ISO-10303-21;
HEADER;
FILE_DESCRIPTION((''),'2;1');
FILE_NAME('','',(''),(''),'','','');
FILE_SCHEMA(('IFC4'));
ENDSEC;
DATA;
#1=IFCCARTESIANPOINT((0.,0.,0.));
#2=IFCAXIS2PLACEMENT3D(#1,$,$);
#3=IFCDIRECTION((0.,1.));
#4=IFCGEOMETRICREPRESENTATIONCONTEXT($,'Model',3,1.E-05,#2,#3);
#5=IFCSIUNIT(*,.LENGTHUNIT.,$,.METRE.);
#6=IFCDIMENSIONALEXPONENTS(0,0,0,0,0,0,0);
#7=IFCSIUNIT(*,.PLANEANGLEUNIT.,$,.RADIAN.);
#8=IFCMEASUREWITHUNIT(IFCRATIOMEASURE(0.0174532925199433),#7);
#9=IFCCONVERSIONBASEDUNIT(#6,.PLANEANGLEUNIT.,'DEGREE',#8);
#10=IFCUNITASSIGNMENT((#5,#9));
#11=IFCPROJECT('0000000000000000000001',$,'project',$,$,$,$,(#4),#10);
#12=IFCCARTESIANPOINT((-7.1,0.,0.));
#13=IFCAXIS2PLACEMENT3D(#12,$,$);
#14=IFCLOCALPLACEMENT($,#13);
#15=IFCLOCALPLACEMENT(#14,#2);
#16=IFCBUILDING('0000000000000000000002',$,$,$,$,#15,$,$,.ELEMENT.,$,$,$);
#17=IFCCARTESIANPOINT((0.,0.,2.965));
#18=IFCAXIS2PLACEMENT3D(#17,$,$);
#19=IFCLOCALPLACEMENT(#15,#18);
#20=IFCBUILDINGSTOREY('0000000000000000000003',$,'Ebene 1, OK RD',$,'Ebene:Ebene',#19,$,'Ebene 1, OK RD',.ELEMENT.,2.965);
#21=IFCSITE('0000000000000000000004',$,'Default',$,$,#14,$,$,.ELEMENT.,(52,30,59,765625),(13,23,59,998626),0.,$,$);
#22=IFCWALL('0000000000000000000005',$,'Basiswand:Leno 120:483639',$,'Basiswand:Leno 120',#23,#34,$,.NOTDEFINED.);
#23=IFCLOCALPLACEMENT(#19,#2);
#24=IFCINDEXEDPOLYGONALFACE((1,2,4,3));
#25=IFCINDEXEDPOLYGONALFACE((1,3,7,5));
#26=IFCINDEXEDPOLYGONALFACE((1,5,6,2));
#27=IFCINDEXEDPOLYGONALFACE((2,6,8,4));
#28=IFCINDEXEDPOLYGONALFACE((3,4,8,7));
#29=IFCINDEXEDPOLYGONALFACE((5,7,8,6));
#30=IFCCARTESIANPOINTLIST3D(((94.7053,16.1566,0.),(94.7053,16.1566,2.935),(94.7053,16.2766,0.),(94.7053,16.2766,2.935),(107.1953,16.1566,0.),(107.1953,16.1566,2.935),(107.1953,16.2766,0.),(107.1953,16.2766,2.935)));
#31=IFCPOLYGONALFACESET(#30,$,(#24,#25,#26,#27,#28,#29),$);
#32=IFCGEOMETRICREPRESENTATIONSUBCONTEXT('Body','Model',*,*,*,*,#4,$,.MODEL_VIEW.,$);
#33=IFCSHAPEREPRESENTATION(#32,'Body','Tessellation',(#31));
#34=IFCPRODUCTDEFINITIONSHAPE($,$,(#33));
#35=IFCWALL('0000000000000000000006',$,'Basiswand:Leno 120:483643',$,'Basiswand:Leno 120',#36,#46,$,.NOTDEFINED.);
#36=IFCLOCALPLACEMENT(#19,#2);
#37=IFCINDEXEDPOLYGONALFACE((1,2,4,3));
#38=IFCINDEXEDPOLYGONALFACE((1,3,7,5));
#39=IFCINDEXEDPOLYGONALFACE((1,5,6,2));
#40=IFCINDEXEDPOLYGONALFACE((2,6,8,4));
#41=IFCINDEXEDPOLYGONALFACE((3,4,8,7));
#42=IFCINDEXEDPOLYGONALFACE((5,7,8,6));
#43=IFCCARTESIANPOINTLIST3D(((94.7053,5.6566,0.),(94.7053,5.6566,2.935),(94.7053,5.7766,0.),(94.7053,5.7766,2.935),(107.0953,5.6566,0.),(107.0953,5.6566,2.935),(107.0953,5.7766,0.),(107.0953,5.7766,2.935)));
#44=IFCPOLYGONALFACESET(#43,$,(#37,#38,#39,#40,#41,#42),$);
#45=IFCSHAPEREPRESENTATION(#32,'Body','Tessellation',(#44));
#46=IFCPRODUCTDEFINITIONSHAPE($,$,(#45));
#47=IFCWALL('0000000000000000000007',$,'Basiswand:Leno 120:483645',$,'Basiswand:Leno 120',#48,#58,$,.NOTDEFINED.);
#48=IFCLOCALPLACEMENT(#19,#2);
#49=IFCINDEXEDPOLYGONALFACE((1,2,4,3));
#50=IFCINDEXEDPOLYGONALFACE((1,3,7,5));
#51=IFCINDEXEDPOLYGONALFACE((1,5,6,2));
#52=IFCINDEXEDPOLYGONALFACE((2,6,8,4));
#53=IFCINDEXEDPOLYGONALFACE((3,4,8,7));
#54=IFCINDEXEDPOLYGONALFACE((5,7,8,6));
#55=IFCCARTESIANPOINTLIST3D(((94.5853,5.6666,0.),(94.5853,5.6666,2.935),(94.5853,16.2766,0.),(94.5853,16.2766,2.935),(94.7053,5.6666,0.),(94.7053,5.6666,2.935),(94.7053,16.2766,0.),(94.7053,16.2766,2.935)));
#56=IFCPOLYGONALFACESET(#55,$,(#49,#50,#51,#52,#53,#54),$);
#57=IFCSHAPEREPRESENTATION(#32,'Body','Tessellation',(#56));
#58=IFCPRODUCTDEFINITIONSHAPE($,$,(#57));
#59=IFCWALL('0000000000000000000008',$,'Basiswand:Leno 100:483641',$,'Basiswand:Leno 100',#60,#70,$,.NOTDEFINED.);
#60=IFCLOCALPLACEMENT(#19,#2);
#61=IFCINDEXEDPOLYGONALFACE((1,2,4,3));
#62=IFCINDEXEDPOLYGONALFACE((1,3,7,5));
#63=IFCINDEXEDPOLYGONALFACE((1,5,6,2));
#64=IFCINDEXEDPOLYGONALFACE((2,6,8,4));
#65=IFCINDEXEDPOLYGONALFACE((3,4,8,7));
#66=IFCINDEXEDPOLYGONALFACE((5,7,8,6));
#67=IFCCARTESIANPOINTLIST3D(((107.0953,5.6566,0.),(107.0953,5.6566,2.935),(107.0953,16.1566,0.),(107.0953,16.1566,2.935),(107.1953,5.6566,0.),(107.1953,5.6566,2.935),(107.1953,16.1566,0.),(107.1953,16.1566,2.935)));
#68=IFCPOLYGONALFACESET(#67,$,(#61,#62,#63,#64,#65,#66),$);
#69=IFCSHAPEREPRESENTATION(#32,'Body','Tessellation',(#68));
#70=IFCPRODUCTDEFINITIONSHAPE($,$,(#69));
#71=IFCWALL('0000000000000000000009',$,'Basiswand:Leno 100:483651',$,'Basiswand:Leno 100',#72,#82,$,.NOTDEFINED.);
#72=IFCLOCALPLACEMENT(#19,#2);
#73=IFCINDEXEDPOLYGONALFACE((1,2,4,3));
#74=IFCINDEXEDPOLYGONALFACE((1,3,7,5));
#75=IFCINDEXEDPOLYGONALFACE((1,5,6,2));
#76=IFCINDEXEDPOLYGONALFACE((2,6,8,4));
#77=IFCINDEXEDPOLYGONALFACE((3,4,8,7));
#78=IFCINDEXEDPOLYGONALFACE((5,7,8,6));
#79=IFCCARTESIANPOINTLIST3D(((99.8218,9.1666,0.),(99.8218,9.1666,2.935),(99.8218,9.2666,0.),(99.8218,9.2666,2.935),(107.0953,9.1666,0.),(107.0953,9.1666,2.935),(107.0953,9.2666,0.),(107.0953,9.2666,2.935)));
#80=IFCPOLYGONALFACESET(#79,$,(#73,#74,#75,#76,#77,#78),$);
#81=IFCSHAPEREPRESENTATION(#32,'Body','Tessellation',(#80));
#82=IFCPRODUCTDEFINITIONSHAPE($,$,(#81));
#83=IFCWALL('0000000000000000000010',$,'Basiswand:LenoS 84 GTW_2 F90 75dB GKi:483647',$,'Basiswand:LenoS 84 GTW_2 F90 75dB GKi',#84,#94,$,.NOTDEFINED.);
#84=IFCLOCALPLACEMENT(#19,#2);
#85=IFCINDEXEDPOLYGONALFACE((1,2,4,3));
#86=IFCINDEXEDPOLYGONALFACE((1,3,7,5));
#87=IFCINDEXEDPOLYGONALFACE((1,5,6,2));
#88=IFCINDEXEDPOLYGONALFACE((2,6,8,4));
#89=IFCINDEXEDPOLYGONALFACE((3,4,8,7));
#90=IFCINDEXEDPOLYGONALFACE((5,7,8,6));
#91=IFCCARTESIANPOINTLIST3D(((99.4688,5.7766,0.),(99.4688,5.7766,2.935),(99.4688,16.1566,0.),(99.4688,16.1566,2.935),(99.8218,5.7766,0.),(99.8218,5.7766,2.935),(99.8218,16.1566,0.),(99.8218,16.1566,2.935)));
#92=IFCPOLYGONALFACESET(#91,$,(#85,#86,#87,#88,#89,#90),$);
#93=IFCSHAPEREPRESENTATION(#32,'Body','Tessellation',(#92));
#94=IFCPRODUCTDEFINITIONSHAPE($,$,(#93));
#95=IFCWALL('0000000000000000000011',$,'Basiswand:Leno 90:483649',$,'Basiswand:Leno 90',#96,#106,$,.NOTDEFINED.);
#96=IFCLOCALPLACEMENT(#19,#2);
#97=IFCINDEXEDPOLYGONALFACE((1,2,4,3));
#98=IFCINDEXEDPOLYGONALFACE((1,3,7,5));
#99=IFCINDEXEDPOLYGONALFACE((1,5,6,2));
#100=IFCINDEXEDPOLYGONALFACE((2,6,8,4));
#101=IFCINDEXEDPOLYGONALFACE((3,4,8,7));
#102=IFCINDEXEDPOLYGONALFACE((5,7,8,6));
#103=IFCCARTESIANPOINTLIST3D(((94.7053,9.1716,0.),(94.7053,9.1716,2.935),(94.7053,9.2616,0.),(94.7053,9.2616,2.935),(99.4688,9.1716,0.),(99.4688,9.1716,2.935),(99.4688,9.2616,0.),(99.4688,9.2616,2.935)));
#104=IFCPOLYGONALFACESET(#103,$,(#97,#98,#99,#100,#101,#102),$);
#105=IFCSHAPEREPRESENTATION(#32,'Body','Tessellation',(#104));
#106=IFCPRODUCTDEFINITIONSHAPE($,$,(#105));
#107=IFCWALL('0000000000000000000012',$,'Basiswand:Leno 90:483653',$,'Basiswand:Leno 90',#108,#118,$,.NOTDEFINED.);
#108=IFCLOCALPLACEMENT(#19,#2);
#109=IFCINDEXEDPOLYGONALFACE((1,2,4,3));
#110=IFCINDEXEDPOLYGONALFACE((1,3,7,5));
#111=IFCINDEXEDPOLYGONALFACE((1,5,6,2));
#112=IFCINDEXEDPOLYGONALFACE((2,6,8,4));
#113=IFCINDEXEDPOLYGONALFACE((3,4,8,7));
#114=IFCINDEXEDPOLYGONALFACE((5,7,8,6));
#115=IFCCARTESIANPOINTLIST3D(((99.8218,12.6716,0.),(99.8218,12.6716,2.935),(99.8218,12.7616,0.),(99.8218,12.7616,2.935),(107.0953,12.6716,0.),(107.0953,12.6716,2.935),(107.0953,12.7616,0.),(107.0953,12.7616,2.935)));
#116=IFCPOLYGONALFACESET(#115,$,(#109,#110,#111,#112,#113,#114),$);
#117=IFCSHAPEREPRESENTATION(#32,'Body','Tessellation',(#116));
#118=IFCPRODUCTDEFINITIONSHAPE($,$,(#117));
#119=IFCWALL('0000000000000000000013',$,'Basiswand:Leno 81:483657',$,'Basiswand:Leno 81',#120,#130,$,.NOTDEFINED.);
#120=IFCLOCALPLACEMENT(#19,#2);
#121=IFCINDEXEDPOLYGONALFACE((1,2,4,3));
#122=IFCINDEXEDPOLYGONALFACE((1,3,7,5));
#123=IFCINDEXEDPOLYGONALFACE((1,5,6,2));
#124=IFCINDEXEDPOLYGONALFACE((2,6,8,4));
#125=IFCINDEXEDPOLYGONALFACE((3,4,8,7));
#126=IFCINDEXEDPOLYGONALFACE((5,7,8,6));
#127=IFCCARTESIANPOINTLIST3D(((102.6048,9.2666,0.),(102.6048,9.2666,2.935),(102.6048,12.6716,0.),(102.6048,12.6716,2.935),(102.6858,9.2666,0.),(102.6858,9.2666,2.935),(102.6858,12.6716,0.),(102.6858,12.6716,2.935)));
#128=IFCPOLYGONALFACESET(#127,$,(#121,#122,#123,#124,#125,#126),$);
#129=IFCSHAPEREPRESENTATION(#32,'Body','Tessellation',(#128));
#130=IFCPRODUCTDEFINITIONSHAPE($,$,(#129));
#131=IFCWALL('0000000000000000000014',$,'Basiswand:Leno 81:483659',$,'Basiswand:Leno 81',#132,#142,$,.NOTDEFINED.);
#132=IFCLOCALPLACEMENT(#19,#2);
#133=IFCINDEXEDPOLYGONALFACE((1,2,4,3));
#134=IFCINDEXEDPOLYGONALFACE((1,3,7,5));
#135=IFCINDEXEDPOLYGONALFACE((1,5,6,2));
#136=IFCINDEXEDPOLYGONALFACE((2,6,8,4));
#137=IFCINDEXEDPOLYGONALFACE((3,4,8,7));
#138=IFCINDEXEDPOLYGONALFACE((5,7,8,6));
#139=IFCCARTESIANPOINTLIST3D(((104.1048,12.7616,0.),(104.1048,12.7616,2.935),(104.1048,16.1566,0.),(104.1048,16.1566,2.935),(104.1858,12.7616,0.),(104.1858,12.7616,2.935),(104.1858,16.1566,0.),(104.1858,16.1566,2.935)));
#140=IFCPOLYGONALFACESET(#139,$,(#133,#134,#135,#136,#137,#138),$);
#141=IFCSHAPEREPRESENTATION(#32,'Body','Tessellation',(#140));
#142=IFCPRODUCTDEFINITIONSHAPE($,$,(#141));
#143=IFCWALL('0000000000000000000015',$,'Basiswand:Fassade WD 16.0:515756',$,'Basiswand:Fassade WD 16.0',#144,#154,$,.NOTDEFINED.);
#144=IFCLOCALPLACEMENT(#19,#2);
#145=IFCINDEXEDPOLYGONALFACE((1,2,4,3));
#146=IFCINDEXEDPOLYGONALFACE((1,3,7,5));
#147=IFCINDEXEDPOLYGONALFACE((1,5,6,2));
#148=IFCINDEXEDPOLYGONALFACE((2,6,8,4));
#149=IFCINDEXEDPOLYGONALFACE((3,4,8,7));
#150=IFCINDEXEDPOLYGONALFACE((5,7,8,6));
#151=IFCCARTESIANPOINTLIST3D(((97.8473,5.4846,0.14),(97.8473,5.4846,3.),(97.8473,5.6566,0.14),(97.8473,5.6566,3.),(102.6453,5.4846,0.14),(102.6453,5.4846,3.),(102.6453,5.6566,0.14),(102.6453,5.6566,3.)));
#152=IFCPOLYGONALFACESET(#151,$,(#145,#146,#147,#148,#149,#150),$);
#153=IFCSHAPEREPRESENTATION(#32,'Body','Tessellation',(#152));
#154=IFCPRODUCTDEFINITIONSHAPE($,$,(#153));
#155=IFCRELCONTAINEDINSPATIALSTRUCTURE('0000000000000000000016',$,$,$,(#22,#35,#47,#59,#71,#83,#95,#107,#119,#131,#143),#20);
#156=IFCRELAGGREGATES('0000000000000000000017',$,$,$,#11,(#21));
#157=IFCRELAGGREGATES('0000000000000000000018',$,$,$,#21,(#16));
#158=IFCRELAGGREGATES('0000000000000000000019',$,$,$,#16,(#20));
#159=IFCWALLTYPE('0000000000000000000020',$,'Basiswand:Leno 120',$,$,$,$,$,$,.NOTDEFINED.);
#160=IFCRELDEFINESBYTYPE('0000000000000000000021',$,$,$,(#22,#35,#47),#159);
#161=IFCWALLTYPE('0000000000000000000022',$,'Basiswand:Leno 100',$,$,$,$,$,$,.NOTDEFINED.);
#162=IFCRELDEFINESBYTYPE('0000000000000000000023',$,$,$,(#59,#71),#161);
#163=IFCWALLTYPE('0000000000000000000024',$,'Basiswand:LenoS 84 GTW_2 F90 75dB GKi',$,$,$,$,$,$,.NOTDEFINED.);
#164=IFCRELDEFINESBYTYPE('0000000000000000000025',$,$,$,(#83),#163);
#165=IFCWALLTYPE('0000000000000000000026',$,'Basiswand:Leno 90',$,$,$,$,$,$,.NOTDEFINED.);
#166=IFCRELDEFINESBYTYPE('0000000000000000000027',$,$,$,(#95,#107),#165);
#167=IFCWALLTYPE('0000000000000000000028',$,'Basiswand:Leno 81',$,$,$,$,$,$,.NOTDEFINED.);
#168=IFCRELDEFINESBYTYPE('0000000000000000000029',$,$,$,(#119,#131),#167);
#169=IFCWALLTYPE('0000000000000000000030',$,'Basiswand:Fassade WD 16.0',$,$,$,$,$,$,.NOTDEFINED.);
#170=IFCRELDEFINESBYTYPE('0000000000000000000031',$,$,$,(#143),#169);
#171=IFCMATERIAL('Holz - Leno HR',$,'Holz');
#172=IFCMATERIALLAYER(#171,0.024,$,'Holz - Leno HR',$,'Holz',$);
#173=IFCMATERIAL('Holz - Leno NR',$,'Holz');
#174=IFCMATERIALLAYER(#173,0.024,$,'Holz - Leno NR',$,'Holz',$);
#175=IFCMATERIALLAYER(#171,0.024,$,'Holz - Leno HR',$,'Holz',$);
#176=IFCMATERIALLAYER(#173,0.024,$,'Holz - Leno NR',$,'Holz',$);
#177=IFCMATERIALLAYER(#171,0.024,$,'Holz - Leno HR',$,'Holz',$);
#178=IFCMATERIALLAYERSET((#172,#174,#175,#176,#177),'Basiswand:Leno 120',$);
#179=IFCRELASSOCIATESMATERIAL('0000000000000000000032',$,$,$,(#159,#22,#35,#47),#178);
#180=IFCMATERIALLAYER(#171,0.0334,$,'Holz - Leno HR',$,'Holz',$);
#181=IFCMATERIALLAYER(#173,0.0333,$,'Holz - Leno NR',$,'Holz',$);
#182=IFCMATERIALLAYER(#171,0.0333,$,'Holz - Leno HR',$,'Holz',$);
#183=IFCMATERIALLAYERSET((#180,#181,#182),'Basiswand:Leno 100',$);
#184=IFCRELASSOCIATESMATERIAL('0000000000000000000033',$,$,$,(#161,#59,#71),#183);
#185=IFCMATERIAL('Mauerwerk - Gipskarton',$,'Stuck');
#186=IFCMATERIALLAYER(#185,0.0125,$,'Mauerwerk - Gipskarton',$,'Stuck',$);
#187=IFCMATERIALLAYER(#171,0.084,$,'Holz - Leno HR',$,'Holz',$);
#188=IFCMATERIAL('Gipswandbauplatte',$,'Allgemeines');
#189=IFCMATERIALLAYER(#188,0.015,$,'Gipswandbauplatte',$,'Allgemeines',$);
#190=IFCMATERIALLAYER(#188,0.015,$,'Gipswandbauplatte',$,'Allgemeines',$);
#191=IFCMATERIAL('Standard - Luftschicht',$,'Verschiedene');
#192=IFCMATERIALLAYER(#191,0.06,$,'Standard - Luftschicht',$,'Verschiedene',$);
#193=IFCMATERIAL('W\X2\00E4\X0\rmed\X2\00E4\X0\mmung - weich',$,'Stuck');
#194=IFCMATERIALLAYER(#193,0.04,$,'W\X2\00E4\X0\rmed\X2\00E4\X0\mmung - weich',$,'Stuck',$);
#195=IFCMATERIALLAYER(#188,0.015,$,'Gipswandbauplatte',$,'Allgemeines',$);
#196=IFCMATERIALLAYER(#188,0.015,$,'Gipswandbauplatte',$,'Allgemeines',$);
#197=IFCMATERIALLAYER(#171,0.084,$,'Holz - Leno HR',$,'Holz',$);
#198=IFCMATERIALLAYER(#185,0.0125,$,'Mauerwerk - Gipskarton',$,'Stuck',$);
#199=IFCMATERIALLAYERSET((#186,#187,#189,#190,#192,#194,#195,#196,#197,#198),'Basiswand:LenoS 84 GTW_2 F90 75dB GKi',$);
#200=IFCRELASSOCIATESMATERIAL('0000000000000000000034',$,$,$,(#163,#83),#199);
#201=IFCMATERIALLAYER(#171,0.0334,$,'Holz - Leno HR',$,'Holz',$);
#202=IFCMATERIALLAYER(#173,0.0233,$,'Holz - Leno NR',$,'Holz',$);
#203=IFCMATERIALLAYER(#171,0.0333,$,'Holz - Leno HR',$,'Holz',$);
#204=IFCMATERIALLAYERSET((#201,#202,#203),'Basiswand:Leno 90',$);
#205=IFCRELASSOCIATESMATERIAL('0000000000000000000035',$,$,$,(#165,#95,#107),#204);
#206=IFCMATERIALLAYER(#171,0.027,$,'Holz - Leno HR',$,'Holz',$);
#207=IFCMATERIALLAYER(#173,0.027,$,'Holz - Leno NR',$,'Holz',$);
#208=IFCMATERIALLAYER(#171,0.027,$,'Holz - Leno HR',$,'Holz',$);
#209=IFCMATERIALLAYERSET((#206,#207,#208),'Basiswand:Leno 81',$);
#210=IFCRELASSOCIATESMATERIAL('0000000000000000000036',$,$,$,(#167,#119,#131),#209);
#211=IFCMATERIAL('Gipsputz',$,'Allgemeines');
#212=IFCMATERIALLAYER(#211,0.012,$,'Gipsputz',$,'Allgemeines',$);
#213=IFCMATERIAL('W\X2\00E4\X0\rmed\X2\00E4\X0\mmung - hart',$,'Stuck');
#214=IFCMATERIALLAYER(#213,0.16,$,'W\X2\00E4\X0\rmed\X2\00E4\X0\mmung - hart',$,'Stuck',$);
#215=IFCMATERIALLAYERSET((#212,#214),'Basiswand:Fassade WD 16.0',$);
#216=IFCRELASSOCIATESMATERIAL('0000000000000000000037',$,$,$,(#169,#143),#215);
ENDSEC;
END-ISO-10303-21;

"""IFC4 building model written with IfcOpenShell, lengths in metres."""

from ifc_helpers import new_model, entity, si_unit, converted_unit, direction, frame, frame_2d, origin, place, context, subcontext, project, spatial, rectangle, extrude, material, layer, layer_set, layer_usage, type_object, element, save


model = new_model("IFC4")

# Units and contexts
model_context = context("Model", 3, precision=1e-05, world=origin(), true_north=direction((0.0, 1.0)))
body_context = subcontext(model_context, "Body", "Model", "MODEL_VIEW")
ifc_project = project(units=[si_unit("LENGTHUNIT", "METRE"), converted_unit("PLANEANGLEUNIT", "DEGREE", entity("IfcRatioMeasure", 0.0174532925199433), si_unit("PLANEANGLEUNIT", "RADIAN"), dimensions=[0, 0, 0, 0, 0, 0, 0])], contexts=[model_context])

# Site, building, storey
site_placement = place(None, frame((-7.1, 0.0, 0.0)))
site = spatial("IfcSite", under=ifc_project, at=site_placement, Name="Default", CompositionType="ELEMENT", RefLatitude=(52, 30, 59, 765625), RefLongitude=(13, 23, 59, 998626), RefElevation=0.0)
building_placement = place(site_placement, origin())
building = spatial("IfcBuilding", under=site, at=building_placement, CompositionType="ELEMENT")
storey_placement = place(building_placement, frame((0.0, 0.0, 2.965)))
storey = spatial("IfcBuildingStorey", under=building, at=storey_placement, Name="Ebene 1, OK RD", ObjectType="Ebene:Ebene", LongName="Ebene 1, OK RD", CompositionType="ELEMENT", Elevation=2.965)

# Shared definitions
ifc_material_1 = material(Name="Holz - Leno HR", Category="Holz")
ifc_material_2 = material(Name="Holz - Leno NR", Category="Holz")
ifc_material_3 = material(Name="Wärmedämmung - hart", Category="Stuck")

# Walls
ifc_layer_1 = layer(ifc_material_1, 0.024, Name="Holz - Leno HR", Category="Holz")
ifc_layer_2 = layer(ifc_material_2, 0.024, Name="Holz - Leno NR", Category="Holz")
ifc_layer_3 = layer(ifc_material_1, 0.024, Name="Holz - Leno HR", Category="Holz")
ifc_layer_4 = layer(ifc_material_2, 0.024, Name="Holz - Leno NR", Category="Holz")
ifc_layer_5 = layer(ifc_material_1, 0.024, Name="Holz - Leno HR", Category="Holz")
ifc_layer_set_1 = layer_set([ifc_layer_1, ifc_layer_2, ifc_layer_3, ifc_layer_4, ifc_layer_5], Name="Basiswand:Leno 120")
ifc_layer_usage_1 = layer_usage(ifc_layer_set_1, "AXIS2", "NEGATIVE", 0.06)
wall_type_1 = type_object("IfcWallType", Name="Basiswand:Leno 120", PredefinedType="NOTDEFINED", material=ifc_layer_set_1)
wall_1_placement = place(storey_placement, frame((94.7053, 16.2166, 0.0)))
element("IfcWall", 1, at=wall_1_placement, inside=storey, type_object=wall_type_1, material=ifc_layer_usage_1, Name="Basiswand:Leno 120:483639", ObjectType="Basiswand:Leno 120", PredefinedType="NOTDEFINED", context=body_context, shape_type="SweptSolid", body=[
    extrude(rectangle(XDim=12.49, YDim=0.12, at=frame_2d((6.245, 0.0), x_axis=(-1.0, 0.0))), origin(), (0.0, 0.0, 1.0), 2.935),
])
ifc_layer_usage_2 = layer_usage(ifc_layer_set_1, "AXIS2", "NEGATIVE", 0.06)
wall_2_placement = place(storey_placement, frame((107.0953, 5.7166, 0.0), z_axis=(0.0, 0.0, 1.0), x_axis=(-1.0, 0.0, 0.0)))
element("IfcWall", 2, at=wall_2_placement, inside=storey, type_object=wall_type_1, material=ifc_layer_usage_2, Name="Basiswand:Leno 120:483643", ObjectType="Basiswand:Leno 120", PredefinedType="NOTDEFINED", context=body_context, shape_type="SweptSolid", body=[
    extrude(rectangle(XDim=12.39, YDim=0.12, at=frame_2d((6.195, 0.0), x_axis=(-1.0, 0.0))), origin(), (0.0, 0.0, 1.0), 2.935),
])
ifc_layer_usage_3 = layer_usage(ifc_layer_set_1, "AXIS2", "NEGATIVE", 0.06)
wall_3_placement = place(storey_placement, frame((94.6453, 5.6666, 0.0), z_axis=(0.0, 0.0, 1.0), x_axis=(0.0, 1.0, 0.0)))
element("IfcWall", 3, at=wall_3_placement, inside=storey, type_object=wall_type_1, material=ifc_layer_usage_3, Name="Basiswand:Leno 120:483645", ObjectType="Basiswand:Leno 120", PredefinedType="NOTDEFINED", context=body_context, shape_type="SweptSolid", body=[
    extrude(rectangle(XDim=10.61, YDim=0.12, at=frame_2d((5.305, 0.0), x_axis=(-1.0, 0.0))), origin(), (0.0, 0.0, 1.0), 2.935),
])
ifc_layer_6 = layer(ifc_material_1, 0.0334, Name="Holz - Leno HR", Category="Holz")
ifc_layer_7 = layer(ifc_material_2, 0.0333, Name="Holz - Leno NR", Category="Holz")
ifc_layer_8 = layer(ifc_material_1, 0.0333, Name="Holz - Leno HR", Category="Holz")
ifc_layer_set_2 = layer_set([ifc_layer_6, ifc_layer_7, ifc_layer_8], Name="Basiswand:Leno 100")
ifc_layer_usage_4 = layer_usage(ifc_layer_set_2, "AXIS2", "NEGATIVE", 0.05)
wall_type_2 = type_object("IfcWallType", Name="Basiswand:Leno 100", PredefinedType="NOTDEFINED", material=ifc_layer_set_2)
wall_4_placement = place(storey_placement, frame((107.1453, 16.1566, 0.0), z_axis=(0.0, 0.0, 1.0), x_axis=(0.0, -1.0, 0.0)))
element("IfcWall", 4, at=wall_4_placement, inside=storey, type_object=wall_type_2, material=ifc_layer_usage_4, Name="Basiswand:Leno 100:483641", ObjectType="Basiswand:Leno 100", PredefinedType="NOTDEFINED", context=body_context, shape_type="SweptSolid", body=[
    extrude(rectangle(XDim=10.5, YDim=0.1, at=frame_2d((5.25, 0.0), x_axis=(-1.0, 0.0))), origin(), (0.0, 0.0, 1.0), 2.935),
])
ifc_layer_usage_5 = layer_usage(ifc_layer_set_2, "AXIS2", "NEGATIVE", 0.05)
wall_5_placement = place(storey_placement, frame((107.0953, 9.2166, 0.0), z_axis=(0.0, 0.0, 1.0), x_axis=(-1.0, 0.0, 0.0)))
element("IfcWall", 5, at=wall_5_placement, inside=storey, type_object=wall_type_2, material=ifc_layer_usage_5, Name="Basiswand:Leno 100:483651", ObjectType="Basiswand:Leno 100", PredefinedType="NOTDEFINED", context=body_context, shape_type="SweptSolid", body=[
    extrude(rectangle(XDim=7.2735, YDim=0.1, at=frame_2d((3.6367, 0.0), x_axis=(-1.0, 0.0))), origin(), (0.0, 0.0, 1.0), 2.935),
])
ifc_material_4 = material(Name="Mauerwerk - Gipskarton", Category="Stuck")
ifc_layer_9 = layer(ifc_material_4, 0.0125, Name="Mauerwerk - Gipskarton", Category="Stuck")
ifc_layer_10 = layer(ifc_material_1, 0.084, Name="Holz - Leno HR", Category="Holz")
ifc_material_5 = material(Name="Gipswandbauplatte", Category="Allgemeines")
ifc_layer_11 = layer(ifc_material_5, 0.015, Name="Gipswandbauplatte", Category="Allgemeines")
ifc_layer_12 = layer(ifc_material_5, 0.015, Name="Gipswandbauplatte", Category="Allgemeines")
ifc_material_6 = material(Name="Standard - Luftschicht", Category="Verschiedene")
ifc_layer_13 = layer(ifc_material_6, 0.06, Name="Standard - Luftschicht", Category="Verschiedene")
ifc_material_7 = material(Name="Wärmedämmung - weich", Category="Stuck")
ifc_layer_14 = layer(ifc_material_7, 0.04, Name="Wärmedämmung - weich", Category="Stuck")
ifc_layer_15 = layer(ifc_material_5, 0.015, Name="Gipswandbauplatte", Category="Allgemeines")
ifc_layer_16 = layer(ifc_material_5, 0.015, Name="Gipswandbauplatte", Category="Allgemeines")
ifc_layer_17 = layer(ifc_material_1, 0.084, Name="Holz - Leno HR", Category="Holz")
ifc_layer_18 = layer(ifc_material_4, 0.0125, Name="Mauerwerk - Gipskarton", Category="Stuck")
ifc_layer_set_3 = layer_set([ifc_layer_9, ifc_layer_10, ifc_layer_11, ifc_layer_12, ifc_layer_13, ifc_layer_14, ifc_layer_15, ifc_layer_16, ifc_layer_17, ifc_layer_18], Name="Basiswand:LenoS 84 GTW_2 F90 75dB GKi")
ifc_layer_usage_6 = layer_usage(ifc_layer_set_3, "AXIS2", "NEGATIVE", 0.1765)
wall_type_3 = type_object("IfcWallType", Name="Basiswand:LenoS 84 GTW_2 F90 75dB GKi", PredefinedType="NOTDEFINED", material=ifc_layer_set_3)
wall_6_placement = place(storey_placement, frame((99.6453, 16.1566, 0.0), z_axis=(0.0, 0.0, 1.0), x_axis=(0.0, -1.0, 0.0)))
element("IfcWall", 6, at=wall_6_placement, inside=storey, type_object=wall_type_3, material=ifc_layer_usage_6, Name="Basiswand:LenoS 84 GTW_2 F90 75dB GKi:483647", ObjectType="Basiswand:LenoS 84 GTW_2 F90 75dB GKi", PredefinedType="NOTDEFINED", context=body_context, shape_type="SweptSolid", body=[
    extrude(rectangle(XDim=10.38, YDim=0.353, at=frame_2d((5.19, 0.0), x_axis=(-1.0, 0.0))), origin(), (0.0, 0.0, 1.0), 2.935),
])
ifc_layer_19 = layer(ifc_material_1, 0.0334, Name="Holz - Leno HR", Category="Holz")
ifc_layer_20 = layer(ifc_material_2, 0.0233, Name="Holz - Leno NR", Category="Holz")
ifc_layer_21 = layer(ifc_material_1, 0.0333, Name="Holz - Leno HR", Category="Holz")
ifc_layer_set_4 = layer_set([ifc_layer_19, ifc_layer_20, ifc_layer_21], Name="Basiswand:Leno 90")
ifc_layer_usage_7 = layer_usage(ifc_layer_set_4, "AXIS2", "NEGATIVE", 0.045)
wall_type_4 = type_object("IfcWallType", Name="Basiswand:Leno 90", PredefinedType="NOTDEFINED", material=ifc_layer_set_4)
wall_7_placement = place(storey_placement, frame((94.7053, 9.2166, 0.0)))
element("IfcWall", 7, at=wall_7_placement, inside=storey, type_object=wall_type_4, material=ifc_layer_usage_7, Name="Basiswand:Leno 90:483649", ObjectType="Basiswand:Leno 90", PredefinedType="NOTDEFINED", context=body_context, shape_type="SweptSolid", body=[
    extrude(rectangle(XDim=4.7635, YDim=0.09, at=frame_2d((2.3817, 0.0), x_axis=(-1.0, 0.0))), origin(), (0.0, 0.0, 1.0), 2.935),
])
ifc_layer_usage_8 = layer_usage(ifc_layer_set_4, "AXIS2", "NEGATIVE", 0.045)
wall_8_placement = place(storey_placement, frame((107.0953, 12.7166, 0.0), z_axis=(0.0, 0.0, 1.0), x_axis=(-1.0, 0.0, 0.0)))
element("IfcWall", 8, at=wall_8_placement, inside=storey, type_object=wall_type_4, material=ifc_layer_usage_8, Name="Basiswand:Leno 90:483653", ObjectType="Basiswand:Leno 90", PredefinedType="NOTDEFINED", context=body_context, shape_type="SweptSolid", body=[
    extrude(rectangle(XDim=7.2735, YDim=0.09, at=frame_2d((3.6367, 0.0), x_axis=(-1.0, 0.0))), origin(), (0.0, 0.0, 1.0), 2.935),
])
ifc_layer_22 = layer(ifc_material_1, 0.027, Name="Holz - Leno HR", Category="Holz")
ifc_layer_23 = layer(ifc_material_2, 0.027, Name="Holz - Leno NR", Category="Holz")
ifc_layer_24 = layer(ifc_material_1, 0.027, Name="Holz - Leno HR", Category="Holz")
ifc_layer_set_5 = layer_set([ifc_layer_22, ifc_layer_23, ifc_layer_24], Name="Basiswand:Leno 81")
ifc_layer_usage_9 = layer_usage(ifc_layer_set_5, "AXIS2", "NEGATIVE", 0.0405)
wall_type_5 = type_object("IfcWallType", Name="Basiswand:Leno 81", PredefinedType="NOTDEFINED", material=ifc_layer_set_5)
wall_9_placement = place(storey_placement, frame((102.6453, 9.2666, 0.0), z_axis=(0.0, 0.0, 1.0), x_axis=(0.0, 1.0, 0.0)))
element("IfcWall", 9, at=wall_9_placement, inside=storey, type_object=wall_type_5, material=ifc_layer_usage_9, Name="Basiswand:Leno 81:483657", ObjectType="Basiswand:Leno 81", PredefinedType="NOTDEFINED", context=body_context, shape_type="SweptSolid", body=[
    extrude(rectangle(XDim=3.405, YDim=0.081, at=frame_2d((1.7025, 0.0), x_axis=(-1.0, 0.0))), origin(), (0.0, 0.0, 1.0), 2.935),
])
ifc_layer_usage_10 = layer_usage(ifc_layer_set_5, "AXIS2", "NEGATIVE", 0.0405)
wall_10_placement = place(storey_placement, frame((104.1453, 12.7616, 0.0), z_axis=(0.0, 0.0, 1.0), x_axis=(0.0, 1.0, 0.0)))
element("IfcWall", 10, at=wall_10_placement, inside=storey, type_object=wall_type_5, material=ifc_layer_usage_10, Name="Basiswand:Leno 81:483659", ObjectType="Basiswand:Leno 81", PredefinedType="NOTDEFINED", context=body_context, shape_type="SweptSolid", body=[
    extrude(rectangle(XDim=3.395, YDim=0.081, at=frame_2d((1.6975, 0.0), x_axis=(-1.0, 0.0))), origin(), (0.0, 0.0, 1.0), 2.935),
])
ifc_material_8 = material(Name="Gipsputz", Category="Allgemeines")
ifc_layer_25 = layer(ifc_material_8, 0.012, Name="Gipsputz", Category="Allgemeines")
ifc_layer_26 = layer(ifc_material_3, 0.16, Name="Wärmedämmung - hart", Category="Stuck")
ifc_layer_set_6 = layer_set([ifc_layer_25, ifc_layer_26], Name="Basiswand:Fassade WD 16.0")
ifc_layer_usage_11 = layer_usage(ifc_layer_set_6, "AXIS2", "NEGATIVE", 0.086)
wall_type_6 = type_object("IfcWallType", Name="Basiswand:Fassade WD 16.0", PredefinedType="NOTDEFINED", material=ifc_layer_set_6)
wall_11_placement = place(storey_placement, frame((102.6453, 5.5706, 0.14), z_axis=(0.0, 0.0, 1.0), x_axis=(-1.0, 0.0, 0.0)))
element("IfcWall", 11, at=wall_11_placement, inside=storey, type_object=wall_type_6, material=ifc_layer_usage_11, Name="Basiswand:Fassade WD 16.0:515756", ObjectType="Basiswand:Fassade WD 16.0", PredefinedType="NOTDEFINED", context=body_context, shape_type="SweptSolid", body=[
    extrude(rectangle(XDim=4.798, YDim=0.172, at=frame_2d((2.399, 0.0), x_axis=(-1.0, 0.0))), origin(), (0.0, 0.0, 1.0), 2.86),
])

save(model, "model.ifc")
